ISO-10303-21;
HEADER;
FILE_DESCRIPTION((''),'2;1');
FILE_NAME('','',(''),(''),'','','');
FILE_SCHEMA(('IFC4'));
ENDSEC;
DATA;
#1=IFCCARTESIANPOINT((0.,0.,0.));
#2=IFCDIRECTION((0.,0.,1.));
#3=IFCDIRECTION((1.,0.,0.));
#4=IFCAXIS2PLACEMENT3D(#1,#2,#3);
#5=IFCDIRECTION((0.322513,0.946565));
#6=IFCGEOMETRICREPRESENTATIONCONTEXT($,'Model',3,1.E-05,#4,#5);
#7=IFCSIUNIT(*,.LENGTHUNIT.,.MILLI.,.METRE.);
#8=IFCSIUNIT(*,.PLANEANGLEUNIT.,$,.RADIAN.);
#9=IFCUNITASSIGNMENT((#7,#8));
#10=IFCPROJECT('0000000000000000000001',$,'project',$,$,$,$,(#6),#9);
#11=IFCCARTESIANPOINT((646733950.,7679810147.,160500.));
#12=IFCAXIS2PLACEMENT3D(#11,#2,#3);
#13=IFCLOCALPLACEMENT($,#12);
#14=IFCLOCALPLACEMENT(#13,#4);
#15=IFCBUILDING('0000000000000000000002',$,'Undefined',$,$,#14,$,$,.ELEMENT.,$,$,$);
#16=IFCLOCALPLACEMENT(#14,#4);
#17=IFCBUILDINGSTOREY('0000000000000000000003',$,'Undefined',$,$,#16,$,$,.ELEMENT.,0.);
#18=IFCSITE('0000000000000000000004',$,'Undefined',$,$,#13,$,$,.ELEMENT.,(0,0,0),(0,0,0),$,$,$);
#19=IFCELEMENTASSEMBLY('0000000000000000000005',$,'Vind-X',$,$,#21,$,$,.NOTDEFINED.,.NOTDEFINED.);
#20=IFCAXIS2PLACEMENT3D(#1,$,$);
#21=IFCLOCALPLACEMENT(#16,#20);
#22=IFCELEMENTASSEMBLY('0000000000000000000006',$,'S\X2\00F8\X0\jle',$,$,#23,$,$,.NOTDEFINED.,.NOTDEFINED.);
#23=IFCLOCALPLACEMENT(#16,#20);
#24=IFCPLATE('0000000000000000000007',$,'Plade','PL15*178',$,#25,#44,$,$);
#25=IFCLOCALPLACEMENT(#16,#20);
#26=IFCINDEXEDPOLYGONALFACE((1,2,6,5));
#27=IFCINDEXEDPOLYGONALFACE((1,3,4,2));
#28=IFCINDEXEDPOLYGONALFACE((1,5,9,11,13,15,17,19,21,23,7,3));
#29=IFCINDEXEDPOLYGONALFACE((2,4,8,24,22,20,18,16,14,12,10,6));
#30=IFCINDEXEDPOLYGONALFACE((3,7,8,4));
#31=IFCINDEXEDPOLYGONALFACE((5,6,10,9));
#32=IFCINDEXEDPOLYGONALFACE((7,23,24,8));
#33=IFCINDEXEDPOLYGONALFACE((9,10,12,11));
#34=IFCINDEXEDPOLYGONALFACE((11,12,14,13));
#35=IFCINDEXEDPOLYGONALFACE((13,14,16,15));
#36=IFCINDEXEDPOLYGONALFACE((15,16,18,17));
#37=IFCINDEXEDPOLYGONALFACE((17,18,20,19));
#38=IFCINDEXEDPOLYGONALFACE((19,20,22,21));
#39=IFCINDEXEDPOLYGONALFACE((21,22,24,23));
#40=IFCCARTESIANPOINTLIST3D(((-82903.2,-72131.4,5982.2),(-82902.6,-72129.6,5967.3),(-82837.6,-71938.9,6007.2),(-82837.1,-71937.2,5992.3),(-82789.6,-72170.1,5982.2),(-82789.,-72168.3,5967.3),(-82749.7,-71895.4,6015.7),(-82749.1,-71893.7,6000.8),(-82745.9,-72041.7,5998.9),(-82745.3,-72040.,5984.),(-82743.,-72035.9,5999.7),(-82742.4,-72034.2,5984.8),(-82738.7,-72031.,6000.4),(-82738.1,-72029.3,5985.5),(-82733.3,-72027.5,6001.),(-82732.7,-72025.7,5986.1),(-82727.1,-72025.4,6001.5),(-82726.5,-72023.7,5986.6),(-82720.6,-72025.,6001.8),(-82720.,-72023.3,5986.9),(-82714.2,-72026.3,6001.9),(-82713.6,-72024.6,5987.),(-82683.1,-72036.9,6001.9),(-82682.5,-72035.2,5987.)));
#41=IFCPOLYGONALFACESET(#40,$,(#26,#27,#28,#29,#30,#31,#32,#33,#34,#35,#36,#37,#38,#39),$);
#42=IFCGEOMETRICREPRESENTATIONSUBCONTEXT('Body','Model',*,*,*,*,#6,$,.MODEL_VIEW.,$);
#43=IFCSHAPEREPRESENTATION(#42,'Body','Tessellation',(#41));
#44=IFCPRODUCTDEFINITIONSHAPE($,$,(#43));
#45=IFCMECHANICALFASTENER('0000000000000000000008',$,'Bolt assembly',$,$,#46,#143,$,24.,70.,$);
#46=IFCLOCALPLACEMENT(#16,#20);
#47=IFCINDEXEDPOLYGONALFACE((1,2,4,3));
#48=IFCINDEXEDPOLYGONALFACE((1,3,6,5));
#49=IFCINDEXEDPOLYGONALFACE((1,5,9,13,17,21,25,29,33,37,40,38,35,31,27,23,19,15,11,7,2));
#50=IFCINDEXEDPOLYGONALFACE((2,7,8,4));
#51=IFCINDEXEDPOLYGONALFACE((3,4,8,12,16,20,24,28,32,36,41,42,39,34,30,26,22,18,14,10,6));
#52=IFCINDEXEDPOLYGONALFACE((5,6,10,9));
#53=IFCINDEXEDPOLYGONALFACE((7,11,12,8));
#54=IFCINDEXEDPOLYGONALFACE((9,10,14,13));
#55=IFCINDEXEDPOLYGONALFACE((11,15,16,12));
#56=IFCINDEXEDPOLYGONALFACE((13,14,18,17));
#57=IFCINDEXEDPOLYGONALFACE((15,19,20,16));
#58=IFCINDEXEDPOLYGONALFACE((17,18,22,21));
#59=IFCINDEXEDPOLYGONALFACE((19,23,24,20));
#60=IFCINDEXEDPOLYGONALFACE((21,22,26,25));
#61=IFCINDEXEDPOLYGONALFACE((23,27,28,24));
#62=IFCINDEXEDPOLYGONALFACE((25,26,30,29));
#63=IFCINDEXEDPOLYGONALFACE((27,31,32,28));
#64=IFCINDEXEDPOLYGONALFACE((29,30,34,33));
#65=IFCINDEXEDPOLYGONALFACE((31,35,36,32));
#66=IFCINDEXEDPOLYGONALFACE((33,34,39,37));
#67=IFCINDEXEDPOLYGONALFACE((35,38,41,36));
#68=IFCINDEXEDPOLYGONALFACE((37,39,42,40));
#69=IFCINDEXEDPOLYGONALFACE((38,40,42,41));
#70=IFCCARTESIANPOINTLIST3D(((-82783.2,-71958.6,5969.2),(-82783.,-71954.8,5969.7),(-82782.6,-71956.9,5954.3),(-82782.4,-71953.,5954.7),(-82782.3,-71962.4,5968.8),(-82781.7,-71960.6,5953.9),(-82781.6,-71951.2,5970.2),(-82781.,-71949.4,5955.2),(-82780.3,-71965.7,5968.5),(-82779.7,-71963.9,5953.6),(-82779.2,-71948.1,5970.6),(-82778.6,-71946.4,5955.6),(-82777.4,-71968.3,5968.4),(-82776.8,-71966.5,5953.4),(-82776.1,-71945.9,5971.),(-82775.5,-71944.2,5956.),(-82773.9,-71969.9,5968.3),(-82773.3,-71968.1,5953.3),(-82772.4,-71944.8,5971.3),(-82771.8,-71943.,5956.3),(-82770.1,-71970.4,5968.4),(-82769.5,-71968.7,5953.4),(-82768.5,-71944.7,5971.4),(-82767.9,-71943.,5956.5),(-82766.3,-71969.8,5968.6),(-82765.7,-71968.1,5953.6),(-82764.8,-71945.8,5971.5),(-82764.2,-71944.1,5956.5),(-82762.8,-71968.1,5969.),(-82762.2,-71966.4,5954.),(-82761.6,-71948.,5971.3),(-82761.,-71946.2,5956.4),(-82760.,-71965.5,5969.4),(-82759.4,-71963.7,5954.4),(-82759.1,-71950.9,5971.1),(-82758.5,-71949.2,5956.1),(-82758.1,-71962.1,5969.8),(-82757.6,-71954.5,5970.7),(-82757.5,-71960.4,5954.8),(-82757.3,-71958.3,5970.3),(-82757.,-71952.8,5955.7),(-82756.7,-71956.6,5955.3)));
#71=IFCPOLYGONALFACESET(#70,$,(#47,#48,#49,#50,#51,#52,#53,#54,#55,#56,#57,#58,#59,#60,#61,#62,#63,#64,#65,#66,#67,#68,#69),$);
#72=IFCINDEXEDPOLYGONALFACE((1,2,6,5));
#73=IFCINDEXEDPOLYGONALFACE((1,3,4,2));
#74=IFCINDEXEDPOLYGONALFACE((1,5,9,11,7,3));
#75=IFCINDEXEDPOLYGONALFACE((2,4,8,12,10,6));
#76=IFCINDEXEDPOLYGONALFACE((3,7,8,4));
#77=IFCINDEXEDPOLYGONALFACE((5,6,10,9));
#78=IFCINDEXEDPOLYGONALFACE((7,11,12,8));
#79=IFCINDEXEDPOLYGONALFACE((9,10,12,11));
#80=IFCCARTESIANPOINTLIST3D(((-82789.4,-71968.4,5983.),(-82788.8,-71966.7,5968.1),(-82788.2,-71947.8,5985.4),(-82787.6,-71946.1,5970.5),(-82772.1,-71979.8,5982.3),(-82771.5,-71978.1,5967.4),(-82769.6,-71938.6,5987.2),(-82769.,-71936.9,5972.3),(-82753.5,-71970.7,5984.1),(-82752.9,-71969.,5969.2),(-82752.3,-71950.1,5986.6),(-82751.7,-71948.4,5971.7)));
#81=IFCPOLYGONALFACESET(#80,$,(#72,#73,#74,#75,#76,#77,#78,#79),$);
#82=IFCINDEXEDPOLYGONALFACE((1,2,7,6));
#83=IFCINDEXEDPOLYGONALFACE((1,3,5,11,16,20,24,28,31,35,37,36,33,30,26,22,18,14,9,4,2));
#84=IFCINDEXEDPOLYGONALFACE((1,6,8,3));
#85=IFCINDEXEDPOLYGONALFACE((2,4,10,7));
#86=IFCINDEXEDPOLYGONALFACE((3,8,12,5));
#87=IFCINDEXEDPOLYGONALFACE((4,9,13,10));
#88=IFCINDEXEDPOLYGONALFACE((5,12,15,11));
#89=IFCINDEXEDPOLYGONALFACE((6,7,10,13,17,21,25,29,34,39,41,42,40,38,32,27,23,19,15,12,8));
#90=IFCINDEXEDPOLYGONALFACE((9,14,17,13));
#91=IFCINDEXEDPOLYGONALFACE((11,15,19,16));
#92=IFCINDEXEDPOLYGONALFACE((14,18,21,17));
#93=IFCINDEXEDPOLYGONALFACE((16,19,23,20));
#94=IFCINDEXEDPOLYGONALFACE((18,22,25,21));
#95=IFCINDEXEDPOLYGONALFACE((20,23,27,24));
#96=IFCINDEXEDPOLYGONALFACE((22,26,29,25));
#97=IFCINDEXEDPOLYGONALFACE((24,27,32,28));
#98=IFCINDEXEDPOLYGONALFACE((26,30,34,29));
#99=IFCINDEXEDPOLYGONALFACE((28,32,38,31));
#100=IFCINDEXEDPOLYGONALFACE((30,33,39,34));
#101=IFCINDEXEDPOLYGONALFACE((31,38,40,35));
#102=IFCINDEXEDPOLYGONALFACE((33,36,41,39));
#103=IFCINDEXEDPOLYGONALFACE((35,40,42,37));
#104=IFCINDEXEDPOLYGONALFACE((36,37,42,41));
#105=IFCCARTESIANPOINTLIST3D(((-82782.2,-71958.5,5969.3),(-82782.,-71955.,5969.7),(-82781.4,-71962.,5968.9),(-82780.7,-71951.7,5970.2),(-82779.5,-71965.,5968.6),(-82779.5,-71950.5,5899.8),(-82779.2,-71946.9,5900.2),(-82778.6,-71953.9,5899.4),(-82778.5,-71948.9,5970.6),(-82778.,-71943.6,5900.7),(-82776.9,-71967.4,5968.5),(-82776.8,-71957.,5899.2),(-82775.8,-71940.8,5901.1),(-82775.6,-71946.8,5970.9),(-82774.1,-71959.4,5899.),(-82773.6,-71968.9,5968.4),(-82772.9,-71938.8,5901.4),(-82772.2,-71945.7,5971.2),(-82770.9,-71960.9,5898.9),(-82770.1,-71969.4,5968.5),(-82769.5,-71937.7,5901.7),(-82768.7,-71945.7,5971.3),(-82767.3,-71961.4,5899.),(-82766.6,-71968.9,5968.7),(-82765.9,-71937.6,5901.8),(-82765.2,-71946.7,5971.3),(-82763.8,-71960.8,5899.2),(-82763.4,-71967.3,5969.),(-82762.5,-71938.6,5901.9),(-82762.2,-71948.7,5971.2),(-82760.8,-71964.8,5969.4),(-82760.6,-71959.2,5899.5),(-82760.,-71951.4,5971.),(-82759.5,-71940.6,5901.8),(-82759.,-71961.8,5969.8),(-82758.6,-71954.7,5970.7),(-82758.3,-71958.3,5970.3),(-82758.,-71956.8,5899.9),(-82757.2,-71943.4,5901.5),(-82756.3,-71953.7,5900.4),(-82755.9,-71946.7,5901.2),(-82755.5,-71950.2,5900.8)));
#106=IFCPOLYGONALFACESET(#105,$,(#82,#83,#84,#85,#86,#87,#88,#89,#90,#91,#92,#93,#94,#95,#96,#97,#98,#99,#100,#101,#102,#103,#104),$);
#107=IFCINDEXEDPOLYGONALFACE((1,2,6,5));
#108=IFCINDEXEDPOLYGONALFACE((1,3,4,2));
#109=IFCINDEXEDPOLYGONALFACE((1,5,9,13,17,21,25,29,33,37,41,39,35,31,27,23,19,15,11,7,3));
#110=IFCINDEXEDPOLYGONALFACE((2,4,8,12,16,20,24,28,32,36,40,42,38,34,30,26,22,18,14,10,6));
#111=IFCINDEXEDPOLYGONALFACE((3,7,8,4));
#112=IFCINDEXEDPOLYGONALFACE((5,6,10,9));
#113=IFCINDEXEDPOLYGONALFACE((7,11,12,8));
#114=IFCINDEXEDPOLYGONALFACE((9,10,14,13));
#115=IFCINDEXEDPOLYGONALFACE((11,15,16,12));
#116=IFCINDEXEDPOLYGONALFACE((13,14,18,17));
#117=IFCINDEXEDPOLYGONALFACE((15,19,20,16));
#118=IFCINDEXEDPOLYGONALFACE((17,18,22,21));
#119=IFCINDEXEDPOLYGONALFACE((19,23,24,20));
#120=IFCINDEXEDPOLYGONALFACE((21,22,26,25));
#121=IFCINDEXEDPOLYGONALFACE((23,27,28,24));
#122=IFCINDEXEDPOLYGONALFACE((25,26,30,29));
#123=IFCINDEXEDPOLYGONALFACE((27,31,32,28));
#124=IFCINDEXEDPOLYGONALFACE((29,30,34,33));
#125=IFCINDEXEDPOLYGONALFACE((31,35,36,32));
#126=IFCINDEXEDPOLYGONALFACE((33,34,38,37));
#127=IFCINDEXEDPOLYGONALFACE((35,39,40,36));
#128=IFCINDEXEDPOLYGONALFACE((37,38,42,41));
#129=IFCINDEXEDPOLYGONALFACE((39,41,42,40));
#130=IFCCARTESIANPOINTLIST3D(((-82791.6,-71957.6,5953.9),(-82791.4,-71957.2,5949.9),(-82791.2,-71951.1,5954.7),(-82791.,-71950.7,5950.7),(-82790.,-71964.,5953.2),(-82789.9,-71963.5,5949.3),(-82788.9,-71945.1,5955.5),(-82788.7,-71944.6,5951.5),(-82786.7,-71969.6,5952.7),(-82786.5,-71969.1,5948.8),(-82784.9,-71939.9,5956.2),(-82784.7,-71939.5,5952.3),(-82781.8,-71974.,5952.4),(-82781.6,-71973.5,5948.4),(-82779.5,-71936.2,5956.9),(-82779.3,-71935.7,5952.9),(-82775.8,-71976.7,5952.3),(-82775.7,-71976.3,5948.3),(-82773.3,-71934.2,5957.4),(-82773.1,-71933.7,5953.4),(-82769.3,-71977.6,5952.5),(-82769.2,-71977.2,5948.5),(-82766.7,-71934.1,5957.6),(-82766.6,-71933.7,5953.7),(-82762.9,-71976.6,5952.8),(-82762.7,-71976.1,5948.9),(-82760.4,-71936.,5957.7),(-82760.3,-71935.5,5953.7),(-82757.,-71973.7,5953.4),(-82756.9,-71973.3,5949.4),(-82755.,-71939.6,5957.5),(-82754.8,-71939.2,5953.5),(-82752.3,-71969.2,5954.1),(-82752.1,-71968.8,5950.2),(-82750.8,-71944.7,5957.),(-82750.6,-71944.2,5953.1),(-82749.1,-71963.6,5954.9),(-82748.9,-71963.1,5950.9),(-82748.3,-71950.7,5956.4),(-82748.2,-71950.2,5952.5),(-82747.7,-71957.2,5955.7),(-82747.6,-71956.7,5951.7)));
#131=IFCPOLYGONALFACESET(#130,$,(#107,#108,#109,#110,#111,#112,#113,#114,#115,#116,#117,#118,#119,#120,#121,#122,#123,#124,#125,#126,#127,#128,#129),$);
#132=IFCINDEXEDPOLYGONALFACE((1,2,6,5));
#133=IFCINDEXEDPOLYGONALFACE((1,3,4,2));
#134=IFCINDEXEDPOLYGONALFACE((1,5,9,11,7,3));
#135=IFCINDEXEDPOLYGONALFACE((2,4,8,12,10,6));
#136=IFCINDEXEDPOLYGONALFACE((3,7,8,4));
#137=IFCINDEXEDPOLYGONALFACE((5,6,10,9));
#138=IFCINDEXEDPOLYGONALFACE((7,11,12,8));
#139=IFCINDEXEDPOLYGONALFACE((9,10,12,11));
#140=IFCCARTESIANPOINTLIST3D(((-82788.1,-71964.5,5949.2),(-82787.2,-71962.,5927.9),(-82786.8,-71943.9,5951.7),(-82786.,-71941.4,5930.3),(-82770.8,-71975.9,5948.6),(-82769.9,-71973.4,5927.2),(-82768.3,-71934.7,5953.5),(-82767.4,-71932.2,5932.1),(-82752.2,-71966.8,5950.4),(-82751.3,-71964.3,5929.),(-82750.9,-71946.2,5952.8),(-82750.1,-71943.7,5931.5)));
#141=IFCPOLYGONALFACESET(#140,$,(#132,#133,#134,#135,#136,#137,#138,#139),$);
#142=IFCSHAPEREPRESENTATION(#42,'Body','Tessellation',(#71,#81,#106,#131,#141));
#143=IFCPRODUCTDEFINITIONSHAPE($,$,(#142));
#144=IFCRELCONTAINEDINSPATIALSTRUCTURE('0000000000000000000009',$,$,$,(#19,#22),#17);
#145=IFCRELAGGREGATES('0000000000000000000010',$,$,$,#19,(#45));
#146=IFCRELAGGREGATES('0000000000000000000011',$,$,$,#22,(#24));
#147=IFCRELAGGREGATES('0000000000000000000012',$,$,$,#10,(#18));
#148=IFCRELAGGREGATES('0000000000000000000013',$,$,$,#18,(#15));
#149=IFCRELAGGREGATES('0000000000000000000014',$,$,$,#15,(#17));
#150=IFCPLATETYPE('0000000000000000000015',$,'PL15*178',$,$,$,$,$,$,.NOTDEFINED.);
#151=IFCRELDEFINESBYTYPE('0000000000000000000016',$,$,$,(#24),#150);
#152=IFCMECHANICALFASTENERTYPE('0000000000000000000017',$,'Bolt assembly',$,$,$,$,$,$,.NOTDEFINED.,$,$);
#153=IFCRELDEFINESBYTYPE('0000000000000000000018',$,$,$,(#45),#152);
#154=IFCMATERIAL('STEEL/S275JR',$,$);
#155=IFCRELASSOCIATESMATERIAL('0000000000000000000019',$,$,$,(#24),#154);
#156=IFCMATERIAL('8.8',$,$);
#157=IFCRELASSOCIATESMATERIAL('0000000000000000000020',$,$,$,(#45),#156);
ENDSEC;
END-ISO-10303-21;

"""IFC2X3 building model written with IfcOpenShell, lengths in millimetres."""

from ifc_helpers import new_model, si_unit, direction, frame, frame_2d, origin_with_axes, origin_2d_with_axis, place, context, subcontext, project, spatial, polyline, circle_curve, parameter, trimmed, segment, composite_curve, circle, outline, extrude, source, transform, mapped, material, type_object, element, aggregate, save


model = new_model("IFC2X3")

# Units and contexts
model_context = context("Model", 3, precision=1e-05, world=origin_with_axes(), true_north=direction((0.322513, 0.946565)))
body_context = subcontext(model_context, "Body", "Model", "MODEL_VIEW")
ifc_project = project(units=[si_unit("LENGTHUNIT", "METRE", prefix="MILLI"), si_unit("PLANEANGLEUNIT", "RADIAN")], contexts=[model_context])

# Site, building, storey
site_placement = place(None, frame((646733950.0, 7679810147.0, 160500.0), z_axis=(0.0, 0.0, 1.0), x_axis=(1.0, 0.0, 0.0)))
site = spatial("IfcSite", under=ifc_project, at=site_placement, Name="Undefined", CompositionType="ELEMENT", RefLatitude=(0, 0, 0), RefLongitude=(0, 0, 0))
building_placement = place(site_placement, origin_with_axes())
building = spatial("IfcBuilding", under=site, at=building_placement, Name="Undefined", CompositionType="ELEMENT")
storey_placement = place(building_placement, origin_with_axes())
storey = spatial("IfcBuildingStorey", under=building, at=storey_placement, Name="Undefined", CompositionType="ELEMENT", Elevation=0.0)

# Element assembly
assembly_1_placement = place(storey_placement, origin_with_axes())
assembly_1 = element("IfcElementAssembly", 1, at=assembly_1_placement, inside=storey, Name="Vind-X", AssemblyPlace="NOTDEFINED", PredefinedType="NOTDEFINED")

# Shared definitions
ifc_material_1 = material(Name="STEEL/S275JR")

# Element assembly, plate
assembly_2_placement = place(storey_placement, origin_with_axes())
assembly_2 = element("IfcElementAssembly", 2, at=assembly_2_placement, inside=storey, Name="Søjle", AssemblyPlace="NOTDEFINED", PredefinedType="NOTDEFINED")
plate_type_1 = type_object("IfcPlateType", Name="PL15*178", PredefinedType="NOTDEFINED")
plate_1_placement = place(assembly_2_placement, frame((-82789.3, -72169.2, 5974.8), z_axis=(-0.039304, -0.115357, 0.992546), x_axis=(0.320109, 0.93951, 0.121869)))
plate_1 = element("IfcPlate", 3, at=plate_1_placement, type_object=plate_type_1, material=ifc_material_1, Name="Plade", Description="PL15*178", context=body_context, shape_type="SweptSolid", body=[
    extrude(outline(composite_curve([segment(polyline([(0.0, 0.0), (136.6, 0.0)]), True, "CONTINUOUS"), segment(trimmed(circle_curve(frame_2d((136.6, -25.0), x_axis=(0.0, 1.0)), 25.0), [parameter(0.0)], [parameter(4.712327)], False, "PARAMETER"), True, "CONTINUOUS"), segment(polyline([(161.6, -25.0), (161.6, -57.9), (274.9, 50.8), (204.9, 120.0), (0.0, 120.0), (0.0, 0.0)]), True, "CONTINUOUS")], self_intersect=True)), frame((0.0, 0.0, -7.5), z_axis=(0.0, 0.0, 1.0), x_axis=(1.0, 0.0, 0.0)), (0.0, 0.0, 1.0), 15.0),
])
ifc_material_2 = material(Name="8.8")
mechanical_fastener_type = type_object("IfcMechanicalFastenerType", Name="Bolt assembly")

# Mechanical fastener
shared_shape_1 = source(origin_with_axes(), body_context, "Body", "SweptSolid", [
    extrude(circle(Radius=13.0, at=origin_2d_with_axis()), frame((0.0, 0.0, 0.0), z_axis=(0.0, 1.0, 0.0), x_axis=(1.0, 0.0, 0.0)), (0.0, 0.0, 1.0), 15.1),
    extrude(outline(polyline([(18.0, -10.4), (18.0, 10.4), (0.0, 20.8), (-18.0, 10.4), (-18.0, -10.4), (0.0, -20.8), (18.0, -10.4)])), frame((0.0, -15.0, 0.0), z_axis=(0.0, 1.0, 0.0), x_axis=(1.0, 0.0, 0.0)), (0.0, 0.0, 1.0), 15.0),
    extrude(circle(Radius=12.0, at=origin_2d_with_axis()), frame((0.0, 0.0, 0.0), z_axis=(0.0, 1.0, 0.0), x_axis=(1.0, 0.0, 0.0)), (0.0, 0.0, 1.0), 70.0),
    extrude(circle(Radius=22.0, at=origin_2d_with_axis()), frame((0.0, 15.0, 0.0), z_axis=(0.0, 1.0, 0.0), x_axis=(1.0, 0.0, 0.0)), (0.0, 0.0, 1.0), 4.0),
    extrude(outline(polyline([(18.0, -10.4), (18.0, 10.4), (0.0, 20.8), (-18.0, 10.4), (-18.0, -10.4), (0.0, -20.8), (18.0, -10.4)])), frame((0.0, 19.0, 0.0), z_axis=(0.0, 1.0, 0.0), x_axis=(1.0, 0.0, 0.0)), (0.0, 0.0, 1.0), 21.5),
])
mechanical_fastener_1_placement = place(assembly_1_placement, frame((-82770.3, -71957.5, 5969.9), z_axis=(-0.893742, -0.440152, -0.086548), x_axis=(-0.446855, 0.890482, 0.0858)))
mechanical_fastener_1 = element("IfcMechanicalFastener", 4, at=mechanical_fastener_1_placement, type_object=mechanical_fastener_type, material=ifc_material_2, Name="Bolt assembly", NominalDiameter=24.0, NominalLength=70.0, context=body_context, shape_type="MappedRepresentation", body=[
    mapped(shared_shape_1, transform((0.0, 0.0, 0.0))),
])
aggregate(assembly_1, [mechanical_fastener_1])
aggregate(assembly_2, [plate_1])

save(model, "model.ifc")
